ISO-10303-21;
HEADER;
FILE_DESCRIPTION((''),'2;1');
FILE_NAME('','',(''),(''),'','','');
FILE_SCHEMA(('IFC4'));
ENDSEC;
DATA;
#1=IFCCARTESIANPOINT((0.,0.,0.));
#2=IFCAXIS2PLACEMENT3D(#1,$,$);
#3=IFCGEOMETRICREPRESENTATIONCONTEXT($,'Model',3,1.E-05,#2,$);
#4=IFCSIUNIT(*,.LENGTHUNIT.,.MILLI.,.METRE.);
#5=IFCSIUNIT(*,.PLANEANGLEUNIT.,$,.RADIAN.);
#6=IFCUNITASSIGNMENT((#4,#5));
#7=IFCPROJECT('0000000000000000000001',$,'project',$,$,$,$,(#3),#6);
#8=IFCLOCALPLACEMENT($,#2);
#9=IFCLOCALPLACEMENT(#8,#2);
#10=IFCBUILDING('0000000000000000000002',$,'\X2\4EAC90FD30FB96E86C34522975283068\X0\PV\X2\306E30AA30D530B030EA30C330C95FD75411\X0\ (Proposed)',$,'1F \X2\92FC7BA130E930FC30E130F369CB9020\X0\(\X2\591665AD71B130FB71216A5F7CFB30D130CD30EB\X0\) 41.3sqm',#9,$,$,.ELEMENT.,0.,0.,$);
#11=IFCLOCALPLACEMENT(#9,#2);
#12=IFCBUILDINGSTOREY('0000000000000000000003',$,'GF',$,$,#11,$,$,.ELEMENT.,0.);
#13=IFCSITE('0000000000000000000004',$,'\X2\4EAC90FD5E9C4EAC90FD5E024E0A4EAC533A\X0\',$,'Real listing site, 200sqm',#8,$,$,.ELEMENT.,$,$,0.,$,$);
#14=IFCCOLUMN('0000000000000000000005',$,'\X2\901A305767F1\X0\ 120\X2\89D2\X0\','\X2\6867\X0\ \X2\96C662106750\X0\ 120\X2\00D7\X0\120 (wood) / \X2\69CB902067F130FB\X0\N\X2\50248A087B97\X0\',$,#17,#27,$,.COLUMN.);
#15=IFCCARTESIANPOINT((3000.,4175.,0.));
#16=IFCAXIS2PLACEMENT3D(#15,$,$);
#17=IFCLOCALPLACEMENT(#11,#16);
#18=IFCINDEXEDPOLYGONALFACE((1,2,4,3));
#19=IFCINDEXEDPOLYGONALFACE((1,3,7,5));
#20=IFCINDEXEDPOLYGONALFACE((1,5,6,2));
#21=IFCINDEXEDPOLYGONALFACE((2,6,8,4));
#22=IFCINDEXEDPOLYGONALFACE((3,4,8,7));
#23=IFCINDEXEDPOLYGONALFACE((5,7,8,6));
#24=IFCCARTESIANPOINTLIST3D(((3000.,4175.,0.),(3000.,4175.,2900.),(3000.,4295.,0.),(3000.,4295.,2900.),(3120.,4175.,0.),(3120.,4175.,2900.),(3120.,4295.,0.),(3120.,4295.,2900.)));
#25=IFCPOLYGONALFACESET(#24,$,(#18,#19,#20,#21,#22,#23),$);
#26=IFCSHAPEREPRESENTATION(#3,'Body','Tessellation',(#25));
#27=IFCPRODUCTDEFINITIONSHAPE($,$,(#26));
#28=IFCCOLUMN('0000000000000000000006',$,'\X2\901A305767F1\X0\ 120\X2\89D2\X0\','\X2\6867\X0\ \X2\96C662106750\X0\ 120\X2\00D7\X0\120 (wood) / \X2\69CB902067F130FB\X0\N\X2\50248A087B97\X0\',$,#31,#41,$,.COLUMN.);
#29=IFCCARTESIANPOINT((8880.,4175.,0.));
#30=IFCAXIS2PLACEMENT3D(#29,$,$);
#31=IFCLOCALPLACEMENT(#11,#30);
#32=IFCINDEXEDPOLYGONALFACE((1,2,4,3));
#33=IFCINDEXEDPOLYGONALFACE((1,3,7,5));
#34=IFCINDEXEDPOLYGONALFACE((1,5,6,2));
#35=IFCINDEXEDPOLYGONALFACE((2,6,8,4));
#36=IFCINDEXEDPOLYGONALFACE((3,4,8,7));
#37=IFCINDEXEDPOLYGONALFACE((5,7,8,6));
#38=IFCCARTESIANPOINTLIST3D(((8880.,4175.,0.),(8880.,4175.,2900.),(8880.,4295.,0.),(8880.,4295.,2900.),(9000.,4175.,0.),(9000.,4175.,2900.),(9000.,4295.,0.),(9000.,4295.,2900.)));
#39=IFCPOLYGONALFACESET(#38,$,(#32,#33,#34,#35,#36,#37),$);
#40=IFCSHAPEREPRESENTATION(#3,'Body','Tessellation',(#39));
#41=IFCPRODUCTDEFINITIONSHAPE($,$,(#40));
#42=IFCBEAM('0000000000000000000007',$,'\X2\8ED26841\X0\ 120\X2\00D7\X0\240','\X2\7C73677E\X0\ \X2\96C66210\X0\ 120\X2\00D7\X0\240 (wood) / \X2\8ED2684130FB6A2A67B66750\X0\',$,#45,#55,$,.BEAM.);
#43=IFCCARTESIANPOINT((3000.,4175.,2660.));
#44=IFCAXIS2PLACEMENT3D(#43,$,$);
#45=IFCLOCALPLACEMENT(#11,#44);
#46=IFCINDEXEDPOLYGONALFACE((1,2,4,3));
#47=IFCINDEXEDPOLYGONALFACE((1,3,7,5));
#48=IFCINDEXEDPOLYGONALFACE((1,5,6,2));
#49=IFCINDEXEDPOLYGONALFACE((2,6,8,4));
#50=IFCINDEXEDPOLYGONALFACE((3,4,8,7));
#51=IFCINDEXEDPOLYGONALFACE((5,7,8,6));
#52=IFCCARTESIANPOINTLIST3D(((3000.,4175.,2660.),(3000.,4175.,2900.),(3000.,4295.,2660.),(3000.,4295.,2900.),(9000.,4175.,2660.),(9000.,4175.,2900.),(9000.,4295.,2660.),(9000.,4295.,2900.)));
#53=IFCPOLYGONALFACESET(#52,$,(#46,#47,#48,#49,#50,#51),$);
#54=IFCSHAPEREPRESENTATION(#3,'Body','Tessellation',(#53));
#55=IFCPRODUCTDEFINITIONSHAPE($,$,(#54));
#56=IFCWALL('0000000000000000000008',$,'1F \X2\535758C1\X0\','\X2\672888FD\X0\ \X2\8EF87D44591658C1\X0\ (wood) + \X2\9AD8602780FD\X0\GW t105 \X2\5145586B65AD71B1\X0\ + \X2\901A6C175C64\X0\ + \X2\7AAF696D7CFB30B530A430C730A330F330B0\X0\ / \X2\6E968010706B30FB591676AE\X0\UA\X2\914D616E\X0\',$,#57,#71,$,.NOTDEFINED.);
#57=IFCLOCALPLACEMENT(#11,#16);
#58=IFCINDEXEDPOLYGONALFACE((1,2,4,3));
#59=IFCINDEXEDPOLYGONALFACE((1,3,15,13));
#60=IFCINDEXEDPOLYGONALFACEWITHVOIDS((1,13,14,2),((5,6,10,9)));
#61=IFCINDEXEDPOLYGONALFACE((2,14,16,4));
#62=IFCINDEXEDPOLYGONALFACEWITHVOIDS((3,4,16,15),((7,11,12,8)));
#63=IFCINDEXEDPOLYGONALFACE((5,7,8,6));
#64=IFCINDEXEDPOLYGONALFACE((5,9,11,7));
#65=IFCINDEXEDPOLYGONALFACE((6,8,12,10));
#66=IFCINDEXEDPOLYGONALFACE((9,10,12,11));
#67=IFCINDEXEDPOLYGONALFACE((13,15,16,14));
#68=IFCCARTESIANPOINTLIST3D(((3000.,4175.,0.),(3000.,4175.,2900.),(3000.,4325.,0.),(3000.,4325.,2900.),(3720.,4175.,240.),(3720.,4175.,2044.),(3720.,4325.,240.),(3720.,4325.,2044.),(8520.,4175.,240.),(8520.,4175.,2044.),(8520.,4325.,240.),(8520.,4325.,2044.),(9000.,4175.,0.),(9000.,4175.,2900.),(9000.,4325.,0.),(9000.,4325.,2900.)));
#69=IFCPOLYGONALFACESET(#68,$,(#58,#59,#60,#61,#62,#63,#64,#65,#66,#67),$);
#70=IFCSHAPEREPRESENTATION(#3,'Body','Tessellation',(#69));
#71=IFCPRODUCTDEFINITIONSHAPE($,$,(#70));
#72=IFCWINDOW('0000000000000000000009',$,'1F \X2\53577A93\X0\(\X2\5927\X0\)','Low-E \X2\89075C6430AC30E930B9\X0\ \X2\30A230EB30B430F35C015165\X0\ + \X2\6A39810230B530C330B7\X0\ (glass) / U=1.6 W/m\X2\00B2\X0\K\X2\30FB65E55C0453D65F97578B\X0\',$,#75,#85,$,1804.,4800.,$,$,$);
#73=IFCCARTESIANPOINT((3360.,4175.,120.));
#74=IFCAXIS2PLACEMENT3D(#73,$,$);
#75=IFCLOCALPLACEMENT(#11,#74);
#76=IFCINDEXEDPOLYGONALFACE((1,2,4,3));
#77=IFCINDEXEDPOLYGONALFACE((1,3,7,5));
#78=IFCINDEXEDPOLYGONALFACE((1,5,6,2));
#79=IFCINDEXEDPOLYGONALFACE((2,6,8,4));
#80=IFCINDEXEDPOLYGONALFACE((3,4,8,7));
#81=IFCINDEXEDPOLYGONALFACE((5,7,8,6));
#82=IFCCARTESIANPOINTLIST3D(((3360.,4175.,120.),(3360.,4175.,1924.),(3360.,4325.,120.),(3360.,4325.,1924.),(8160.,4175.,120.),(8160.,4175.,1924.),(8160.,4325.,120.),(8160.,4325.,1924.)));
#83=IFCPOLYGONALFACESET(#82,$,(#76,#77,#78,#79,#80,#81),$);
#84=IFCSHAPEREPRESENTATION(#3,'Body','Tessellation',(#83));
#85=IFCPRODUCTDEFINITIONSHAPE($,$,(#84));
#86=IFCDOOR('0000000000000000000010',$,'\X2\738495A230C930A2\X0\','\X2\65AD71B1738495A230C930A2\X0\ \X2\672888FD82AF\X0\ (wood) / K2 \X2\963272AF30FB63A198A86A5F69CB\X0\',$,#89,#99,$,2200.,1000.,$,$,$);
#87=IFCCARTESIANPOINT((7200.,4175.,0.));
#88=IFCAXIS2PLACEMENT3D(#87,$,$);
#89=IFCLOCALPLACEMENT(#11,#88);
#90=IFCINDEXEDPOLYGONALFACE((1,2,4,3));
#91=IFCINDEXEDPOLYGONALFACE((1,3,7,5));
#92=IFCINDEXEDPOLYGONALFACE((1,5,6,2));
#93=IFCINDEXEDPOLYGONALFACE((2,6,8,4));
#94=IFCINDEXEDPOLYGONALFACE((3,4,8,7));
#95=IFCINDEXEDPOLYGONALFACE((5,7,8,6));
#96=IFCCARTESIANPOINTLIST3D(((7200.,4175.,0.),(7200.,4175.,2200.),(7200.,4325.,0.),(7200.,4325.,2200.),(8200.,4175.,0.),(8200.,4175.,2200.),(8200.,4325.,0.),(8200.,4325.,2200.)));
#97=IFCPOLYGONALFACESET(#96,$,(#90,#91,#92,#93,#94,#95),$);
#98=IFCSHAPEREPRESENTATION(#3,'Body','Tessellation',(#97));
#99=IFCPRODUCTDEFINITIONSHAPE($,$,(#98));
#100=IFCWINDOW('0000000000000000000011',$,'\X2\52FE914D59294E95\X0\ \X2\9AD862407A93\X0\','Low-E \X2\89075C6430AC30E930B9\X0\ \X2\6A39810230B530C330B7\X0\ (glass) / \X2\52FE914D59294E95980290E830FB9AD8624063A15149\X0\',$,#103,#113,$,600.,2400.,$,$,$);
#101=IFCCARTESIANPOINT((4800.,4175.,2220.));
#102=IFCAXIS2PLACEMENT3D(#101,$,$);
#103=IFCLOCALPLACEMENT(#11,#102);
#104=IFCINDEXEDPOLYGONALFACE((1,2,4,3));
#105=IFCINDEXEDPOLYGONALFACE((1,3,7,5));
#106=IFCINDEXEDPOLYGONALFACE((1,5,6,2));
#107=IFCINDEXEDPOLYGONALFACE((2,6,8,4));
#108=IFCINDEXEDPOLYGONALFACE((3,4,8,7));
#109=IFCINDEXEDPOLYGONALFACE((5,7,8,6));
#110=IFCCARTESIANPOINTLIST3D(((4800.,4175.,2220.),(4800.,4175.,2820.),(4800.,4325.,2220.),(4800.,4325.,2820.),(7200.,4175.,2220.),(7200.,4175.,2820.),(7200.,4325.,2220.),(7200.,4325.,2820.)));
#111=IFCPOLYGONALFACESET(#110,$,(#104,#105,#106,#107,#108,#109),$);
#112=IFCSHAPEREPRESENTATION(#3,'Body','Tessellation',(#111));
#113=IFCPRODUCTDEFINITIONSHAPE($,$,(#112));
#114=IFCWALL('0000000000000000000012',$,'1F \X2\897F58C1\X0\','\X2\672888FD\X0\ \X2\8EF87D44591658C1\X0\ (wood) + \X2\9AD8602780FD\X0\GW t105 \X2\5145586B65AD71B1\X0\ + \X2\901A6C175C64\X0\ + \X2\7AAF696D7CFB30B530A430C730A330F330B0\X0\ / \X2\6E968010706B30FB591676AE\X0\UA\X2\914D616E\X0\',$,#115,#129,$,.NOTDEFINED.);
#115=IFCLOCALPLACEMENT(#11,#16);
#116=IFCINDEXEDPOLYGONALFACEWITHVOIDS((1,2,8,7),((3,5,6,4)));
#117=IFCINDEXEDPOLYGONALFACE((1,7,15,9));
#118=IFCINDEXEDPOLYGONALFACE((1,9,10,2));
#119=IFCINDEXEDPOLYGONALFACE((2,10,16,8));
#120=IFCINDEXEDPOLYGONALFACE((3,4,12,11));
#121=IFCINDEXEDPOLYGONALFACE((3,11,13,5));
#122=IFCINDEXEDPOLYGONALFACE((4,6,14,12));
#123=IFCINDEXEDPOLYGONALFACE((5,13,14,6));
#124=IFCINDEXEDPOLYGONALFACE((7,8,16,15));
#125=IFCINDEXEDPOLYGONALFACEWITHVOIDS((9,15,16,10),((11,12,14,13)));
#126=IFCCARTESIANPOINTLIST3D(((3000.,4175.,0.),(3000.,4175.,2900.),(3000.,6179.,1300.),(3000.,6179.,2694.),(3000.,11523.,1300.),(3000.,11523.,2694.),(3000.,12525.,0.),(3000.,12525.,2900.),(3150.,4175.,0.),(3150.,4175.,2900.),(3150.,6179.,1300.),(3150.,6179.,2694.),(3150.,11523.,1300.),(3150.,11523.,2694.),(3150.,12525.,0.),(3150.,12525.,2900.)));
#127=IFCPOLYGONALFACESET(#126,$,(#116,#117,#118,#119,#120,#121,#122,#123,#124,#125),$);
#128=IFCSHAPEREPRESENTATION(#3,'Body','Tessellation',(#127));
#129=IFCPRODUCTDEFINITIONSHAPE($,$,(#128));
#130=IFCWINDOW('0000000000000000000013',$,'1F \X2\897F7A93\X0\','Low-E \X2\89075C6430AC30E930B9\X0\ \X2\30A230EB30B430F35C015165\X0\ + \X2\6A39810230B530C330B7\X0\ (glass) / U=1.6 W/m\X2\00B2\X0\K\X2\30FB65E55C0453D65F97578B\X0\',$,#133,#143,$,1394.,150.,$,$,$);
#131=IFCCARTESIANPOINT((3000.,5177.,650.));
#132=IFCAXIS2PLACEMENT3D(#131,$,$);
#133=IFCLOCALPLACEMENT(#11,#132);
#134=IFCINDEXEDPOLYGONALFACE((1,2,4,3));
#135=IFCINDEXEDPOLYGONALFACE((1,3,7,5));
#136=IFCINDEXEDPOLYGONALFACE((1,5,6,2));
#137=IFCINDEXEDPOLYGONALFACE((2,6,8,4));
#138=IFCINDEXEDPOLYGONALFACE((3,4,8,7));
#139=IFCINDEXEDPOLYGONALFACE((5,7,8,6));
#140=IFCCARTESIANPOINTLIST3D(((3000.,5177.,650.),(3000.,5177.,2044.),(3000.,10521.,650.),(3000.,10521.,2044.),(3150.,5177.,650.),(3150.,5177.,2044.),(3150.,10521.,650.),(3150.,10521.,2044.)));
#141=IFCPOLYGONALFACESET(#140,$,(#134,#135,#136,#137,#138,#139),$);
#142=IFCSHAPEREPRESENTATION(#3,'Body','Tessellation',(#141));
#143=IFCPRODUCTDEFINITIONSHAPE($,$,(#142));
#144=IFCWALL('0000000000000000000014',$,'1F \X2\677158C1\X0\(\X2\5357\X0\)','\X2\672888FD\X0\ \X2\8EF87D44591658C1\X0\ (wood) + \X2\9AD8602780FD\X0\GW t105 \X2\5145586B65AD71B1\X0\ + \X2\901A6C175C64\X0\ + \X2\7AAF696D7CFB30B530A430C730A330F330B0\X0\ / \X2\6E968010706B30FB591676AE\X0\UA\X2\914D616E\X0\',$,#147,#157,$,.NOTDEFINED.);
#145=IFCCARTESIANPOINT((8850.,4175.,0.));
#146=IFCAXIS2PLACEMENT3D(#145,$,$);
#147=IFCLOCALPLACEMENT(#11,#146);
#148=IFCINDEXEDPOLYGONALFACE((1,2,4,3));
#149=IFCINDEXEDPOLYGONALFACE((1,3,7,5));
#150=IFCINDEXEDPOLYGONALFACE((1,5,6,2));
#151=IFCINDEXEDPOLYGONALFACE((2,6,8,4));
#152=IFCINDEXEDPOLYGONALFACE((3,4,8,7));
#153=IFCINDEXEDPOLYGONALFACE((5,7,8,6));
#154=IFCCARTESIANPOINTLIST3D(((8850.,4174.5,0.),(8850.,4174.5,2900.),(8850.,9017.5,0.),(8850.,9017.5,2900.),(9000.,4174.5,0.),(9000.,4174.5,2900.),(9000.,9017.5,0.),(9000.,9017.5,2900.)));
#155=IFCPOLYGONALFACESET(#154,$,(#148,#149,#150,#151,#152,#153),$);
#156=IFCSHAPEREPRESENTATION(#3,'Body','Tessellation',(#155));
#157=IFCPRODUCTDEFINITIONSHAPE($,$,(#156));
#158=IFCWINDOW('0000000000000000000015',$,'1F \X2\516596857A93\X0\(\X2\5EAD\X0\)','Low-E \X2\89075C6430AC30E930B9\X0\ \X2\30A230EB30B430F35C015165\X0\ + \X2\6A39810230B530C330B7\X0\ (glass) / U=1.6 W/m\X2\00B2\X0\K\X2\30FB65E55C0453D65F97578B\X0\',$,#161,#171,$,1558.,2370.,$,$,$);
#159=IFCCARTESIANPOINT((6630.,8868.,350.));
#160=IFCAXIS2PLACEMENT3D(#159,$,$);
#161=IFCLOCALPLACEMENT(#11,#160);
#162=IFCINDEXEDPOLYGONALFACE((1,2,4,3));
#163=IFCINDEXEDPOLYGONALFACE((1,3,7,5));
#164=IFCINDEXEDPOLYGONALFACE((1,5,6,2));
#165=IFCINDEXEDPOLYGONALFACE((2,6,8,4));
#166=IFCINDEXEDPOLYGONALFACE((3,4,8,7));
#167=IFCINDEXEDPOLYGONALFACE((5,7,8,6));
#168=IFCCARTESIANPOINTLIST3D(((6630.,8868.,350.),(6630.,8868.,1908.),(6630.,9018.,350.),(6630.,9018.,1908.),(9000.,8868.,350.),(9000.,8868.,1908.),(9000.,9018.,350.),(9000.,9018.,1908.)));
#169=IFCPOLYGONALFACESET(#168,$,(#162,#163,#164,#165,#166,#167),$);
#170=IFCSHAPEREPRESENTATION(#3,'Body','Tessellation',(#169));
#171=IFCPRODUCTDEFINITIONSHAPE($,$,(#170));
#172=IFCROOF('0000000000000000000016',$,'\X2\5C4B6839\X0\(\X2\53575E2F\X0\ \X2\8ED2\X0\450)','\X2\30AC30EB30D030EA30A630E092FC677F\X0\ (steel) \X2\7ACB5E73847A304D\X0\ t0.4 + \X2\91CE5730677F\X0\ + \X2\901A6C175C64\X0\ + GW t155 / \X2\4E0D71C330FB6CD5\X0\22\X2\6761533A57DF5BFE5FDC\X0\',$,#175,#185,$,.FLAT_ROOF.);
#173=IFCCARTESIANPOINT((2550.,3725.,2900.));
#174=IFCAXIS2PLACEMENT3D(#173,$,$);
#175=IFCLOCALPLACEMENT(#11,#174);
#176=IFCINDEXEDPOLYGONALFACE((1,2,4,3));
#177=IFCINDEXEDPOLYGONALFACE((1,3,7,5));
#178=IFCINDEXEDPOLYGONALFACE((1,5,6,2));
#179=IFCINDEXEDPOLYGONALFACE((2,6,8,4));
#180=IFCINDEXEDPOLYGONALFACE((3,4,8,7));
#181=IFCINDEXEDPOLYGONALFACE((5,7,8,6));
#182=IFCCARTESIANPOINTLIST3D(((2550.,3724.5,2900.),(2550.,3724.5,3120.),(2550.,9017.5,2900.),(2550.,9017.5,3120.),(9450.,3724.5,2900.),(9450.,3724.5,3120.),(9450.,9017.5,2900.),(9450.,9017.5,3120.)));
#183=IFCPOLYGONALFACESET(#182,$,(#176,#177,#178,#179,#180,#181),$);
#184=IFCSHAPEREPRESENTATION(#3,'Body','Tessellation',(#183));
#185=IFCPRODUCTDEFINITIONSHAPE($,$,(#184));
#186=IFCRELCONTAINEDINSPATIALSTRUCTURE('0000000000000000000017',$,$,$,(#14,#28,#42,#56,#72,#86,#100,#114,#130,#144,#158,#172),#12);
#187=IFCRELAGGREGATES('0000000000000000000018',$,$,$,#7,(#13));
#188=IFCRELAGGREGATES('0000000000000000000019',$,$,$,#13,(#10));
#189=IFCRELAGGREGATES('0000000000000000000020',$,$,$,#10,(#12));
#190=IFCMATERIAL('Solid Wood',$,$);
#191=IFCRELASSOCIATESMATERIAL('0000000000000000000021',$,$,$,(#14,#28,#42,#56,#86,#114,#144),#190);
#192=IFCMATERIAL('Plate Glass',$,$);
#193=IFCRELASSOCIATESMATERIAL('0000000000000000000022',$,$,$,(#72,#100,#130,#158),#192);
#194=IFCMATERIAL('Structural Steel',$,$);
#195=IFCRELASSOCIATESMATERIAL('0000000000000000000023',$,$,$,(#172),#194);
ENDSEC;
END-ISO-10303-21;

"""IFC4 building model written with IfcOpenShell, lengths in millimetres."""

from ifc_helpers import new_model, si_unit, frame, frame_2d, origin, place, context, project, spatial, rectangle, extrude, material, element, fill, save


model = new_model("IFC4")

# Units and contexts
model_context = context("Model", 3, precision=1e-05, world=origin())
ifc_project = project(units=[si_unit("LENGTHUNIT", "METRE", prefix="MILLI"), si_unit("PLANEANGLEUNIT", "RADIAN")], contexts=[model_context])

# Site, building, storey
site_placement = place(None, origin())
site = spatial("IfcSite", under=ifc_project, at=site_placement, Name="京都府京都市上京区", ObjectType="Real listing site, 200sqm", CompositionType="ELEMENT", RefElevation=0.0)
building_placement = place(site_placement, origin())
building = spatial("IfcBuilding", under=site, at=building_placement, Name="京都・雨水利用とPVのオフグリッド志向 (Proposed)", ObjectType="1F 鋼管ラーメン構造(外断熱・無機系パネル) 41.3sqm", CompositionType="ELEMENT", ElevationOfRefHeight=0.0, ElevationOfTerrain=0.0)
storey_placement = place(building_placement, origin())
storey = spatial("IfcBuildingStorey", under=building, at=storey_placement, Name="GF", CompositionType="ELEMENT", Elevation=0.0)

# Columns
ifc_material_1 = material(Name="Solid Wood")
column_1_placement = place(storey_placement, frame((3000.0, 4175.0, 0.0)))
element("IfcColumn", 1, at=column_1_placement, inside=storey, material=ifc_material_1, Name="通し柱 120角", Description="桧 集成材 120×120 (wood) / 構造柱・N値計算", PredefinedType="COLUMN", context=model_context, shape_type="SweptSolid", body=[
    extrude(rectangle(XDim=120.0, YDim=120.0, at=frame_2d((60.0, 60.0))), frame((3000.0, 4175.0, 0.0)), (0.0, 0.0, 1.0), 2900.0),
])
column_2_placement = place(storey_placement, frame((8880.0, 4175.0, 0.0)))
element("IfcColumn", 2, at=column_2_placement, inside=storey, material=ifc_material_1, Name="通し柱 120角", Description="桧 集成材 120×120 (wood) / 構造柱・N値計算", PredefinedType="COLUMN", context=model_context, shape_type="SweptSolid", body=[
    extrude(rectangle(XDim=120.0, YDim=120.0, at=frame_2d((60.0, 60.0))), frame((8880.0, 4175.0, 0.0)), (0.0, 0.0, 1.0), 2900.0),
])

# Beam
beam_1_placement = place(storey_placement, frame((3000.0, 4175.0, 2660.0)))
element("IfcBeam", 3, at=beam_1_placement, inside=storey, material=ifc_material_1, Name="軒桁 120×240", Description="米松 集成 120×240 (wood) / 軒桁・横架材", PredefinedType="BEAM", context=model_context, shape_type="SweptSolid", body=[
    extrude(rectangle(XDim=6000.0, YDim=120.0, at=frame_2d((3000.0, 60.0))), frame((3000.0, 4175.0, 2660.0)), (0.0, 0.0, 1.0), 240.0),
])

# Wall, openings, windows, door
wall_1_placement = place(storey_placement, frame((3000.0, 4175.0, 0.0)))
wall_1 = element("IfcWall", 4, at=wall_1_placement, inside=storey, material=ifc_material_1, Name="1F 南壁", Description="木製 軸組外壁 (wood) + 高性能GW t105 充填断熱 + 通気層 + 窯業系サイディング / 準耐火・外皮UA配慮", PredefinedType="NOTDEFINED", context=model_context, shape_type="SweptSolid", body=[
    extrude(rectangle(XDim=6000.0, YDim=150.0, at=frame_2d((3000.0, 75.0))), frame((3000.0, 4175.0, 0.0)), (0.0, 0.0, 1.0), 2900.0),
])
opening_1_placement = place(storey_placement, frame((3360.0, 4175.0, 120.0)))
opening_1 = element("IfcOpeningElement", 5, at=opening_1_placement, cuts=wall_1, PredefinedType="NOTDEFINED", context=model_context, shape_type="SweptSolid", body=[
    extrude(rectangle(XDim=4800.0, YDim=150.0, at=frame_2d((2400.0, 75.0))), frame((3360.0, 4175.0, 120.0)), (0.0, 0.0, 1.0), 1804.0),
])
opening_2_placement = place(storey_placement, frame((7200.0, 4175.0, 0.0)))
opening_2 = element("IfcOpeningElement", 6, at=opening_2_placement, cuts=wall_1, PredefinedType="NOTDEFINED", context=model_context, shape_type="SweptSolid", body=[
    extrude(rectangle(XDim=1000.0, YDim=150.0, at=frame_2d((500.0, 75.0))), frame((7200.0, 4175.0, 0.0)), (0.0, 0.0, 1.0), 2200.0),
])
opening_3_placement = place(storey_placement, frame((4800.0, 4175.0, 2220.0)))
opening_3 = element("IfcOpeningElement", 7, at=opening_3_placement, cuts=wall_1, PredefinedType="NOTDEFINED", context=model_context, shape_type="SweptSolid", body=[
    extrude(rectangle(XDim=2400.0, YDim=150.0, at=frame_2d((1200.0, 75.0))), frame((4800.0, 4175.0, 2220.0)), (0.0, 0.0, 1.0), 600.0),
])
ifc_material_2 = material(Name="Plate Glass")
window_1_placement = place(storey_placement, frame((3360.0, 4175.0, 120.0)))
window_1 = element("IfcWindow", 8, at=window_1_placement, inside=storey, material=ifc_material_2, Name="1F 南窓(大)", Description="Low-E 複層ガラス アルゴン封入 + 樹脂サッシ (glass) / U=1.6 W/m²K・日射取得型", OverallHeight=1804.0, OverallWidth=4800.0, context=model_context, shape_type="SweptSolid", body=[
    extrude(rectangle(XDim=4800.0, YDim=150.0, at=frame_2d((2400.0, 75.0))), frame((3360.0, 4175.0, 120.0)), (0.0, 0.0, 1.0), 1804.0),
])
fill(opening_1, window_1)
door_1_placement = place(storey_placement, frame((7200.0, 4175.0, 0.0)))
door_1 = element("IfcDoor", 9, at=door_1_placement, inside=storey, material=ifc_material_1, Name="玄関ドア", Description="断熱玄関ドア 木製芯 (wood) / K2 防犯・採風機構", OverallHeight=2200.0, OverallWidth=1000.0, context=model_context, shape_type="SweptSolid", body=[
    extrude(rectangle(XDim=1000.0, YDim=150.0, at=frame_2d((500.0, 75.0))), frame((7200.0, 4175.0, 0.0)), (0.0, 0.0, 1.0), 2200.0),
])
fill(opening_2, door_1)
window_2_placement = place(storey_placement, frame((4800.0, 4175.0, 2220.0)))
window_2 = element("IfcWindow", 10, at=window_2_placement, inside=storey, material=ifc_material_2, Name="勾配天井 高所窓", Description="Low-E 複層ガラス 樹脂サッシ (glass) / 勾配天井頂部・高所採光", OverallHeight=600.0, OverallWidth=2400.0, context=model_context, shape_type="SweptSolid", body=[
    extrude(rectangle(XDim=2400.0, YDim=150.0, at=frame_2d((1200.0, 75.0))), frame((4800.0, 4175.0, 2220.0)), (0.0, 0.0, 1.0), 600.0),
])
fill(opening_3, window_2)

# Walls, openings, windows
wall_2_placement = place(storey_placement, frame((3000.0, 4175.0, 0.0)))
wall_2 = element("IfcWall", 11, at=wall_2_placement, inside=storey, material=ifc_material_1, Name="1F 西壁", Description="木製 軸組外壁 (wood) + 高性能GW t105 充填断熱 + 通気層 + 窯業系サイディング / 準耐火・外皮UA配慮", PredefinedType="NOTDEFINED", context=model_context, shape_type="SweptSolid", body=[
    extrude(rectangle(XDim=150.0, YDim=8350.0, at=frame_2d((75.0, 4175.0))), frame((3000.0, 4175.0, 0.0)), (0.0, 0.0, 1.0), 2900.0),
])
opening_4_placement = place(storey_placement, frame((3000.0, 5177.0, 650.0)))
opening_4 = element("IfcOpeningElement", 12, at=opening_4_placement, cuts=wall_2, PredefinedType="NOTDEFINED", context=model_context, shape_type="SweptSolid", body=[
    extrude(rectangle(XDim=150.0, YDim=5344.0, at=frame_2d((75.0, 2672.0))), frame((3000.0, 5177.0, 650.0)), (0.0, 0.0, 1.0), 1394.0),
])
window_3_placement = place(storey_placement, frame((3000.0, 5177.0, 650.0)))
window_3 = element("IfcWindow", 13, at=window_3_placement, inside=storey, material=ifc_material_2, Name="1F 西窓", Description="Low-E 複層ガラス アルゴン封入 + 樹脂サッシ (glass) / U=1.6 W/m²K・日射取得型", OverallHeight=1394.0, OverallWidth=150.0, context=model_context, shape_type="SweptSolid", body=[
    extrude(rectangle(XDim=150.0, YDim=5344.0, at=frame_2d((75.0, 2672.0))), frame((3000.0, 5177.0, 650.0)), (0.0, 0.0, 1.0), 1394.0),
])
fill(opening_4, window_3)
wall_3_placement = place(storey_placement, frame((8850.0, 4175.0, 0.0)))
wall_3 = element("IfcWall", 14, at=wall_3_placement, inside=storey, material=ifc_material_1, Name="1F 東壁(南)", Description="木製 軸組外壁 (wood) + 高性能GW t105 充填断熱 + 通気層 + 窯業系サイディング / 準耐火・外皮UA配慮", PredefinedType="NOTDEFINED", context=model_context, shape_type="SweptSolid", body=[
    extrude(rectangle(XDim=150.0, YDim=4843.0, at=frame_2d((75.0, 2421.0))), frame((8850.0, 4175.0, 0.0)), (0.0, 0.0, 1.0), 2900.0),
])
opening_5_placement = place(storey_placement, frame((6630.0, 8868.0, 350.0)))
opening_5 = element("IfcOpeningElement", 15, at=opening_5_placement, cuts=wall_3, PredefinedType="NOTDEFINED", context=model_context, shape_type="SweptSolid", body=[
    extrude(rectangle(XDim=2370.0, YDim=150.0, at=frame_2d((1185.0, 75.0))), frame((6630.0, 8868.0, 350.0)), (0.0, 0.0, 1.0), 1558.0),
])
window_4_placement = place(storey_placement, frame((6630.0, 8868.0, 350.0)))
window_4 = element("IfcWindow", 16, at=window_4_placement, inside=storey, material=ifc_material_2, Name="1F 入隅窓(庭)", Description="Low-E 複層ガラス アルゴン封入 + 樹脂サッシ (glass) / U=1.6 W/m²K・日射取得型", OverallHeight=1558.0, OverallWidth=2370.0, context=model_context, shape_type="SweptSolid", body=[
    extrude(rectangle(XDim=2370.0, YDim=150.0, at=frame_2d((1185.0, 75.0))), frame((6630.0, 8868.0, 350.0)), (0.0, 0.0, 1.0), 1558.0),
])
fill(opening_5, window_4)

# Roof
ifc_material_3 = material(Name="Structural Steel")
roof_placement = place(storey_placement, frame((2550.0, 3725.0, 2900.0)))
element("IfcRoof", 17, at=roof_placement, inside=storey, material=ifc_material_3, Name="屋根(南帯 軒450)", Description="ガルバリウム鋼板 (steel) 立平葺き t0.4 + 野地板 + 通気層 + GW t155 / 不燃・法22条区域対応", PredefinedType="FLAT_ROOF", context=model_context, shape_type="SweptSolid", body=[
    extrude(rectangle(XDim=6900.0, YDim=5293.0, at=frame_2d((3450.0, 2646.0))), frame((2550.0, 3725.0, 2900.0)), (0.0, 0.0, 1.0), 220.0),
])

save(model, "model.ifc")
